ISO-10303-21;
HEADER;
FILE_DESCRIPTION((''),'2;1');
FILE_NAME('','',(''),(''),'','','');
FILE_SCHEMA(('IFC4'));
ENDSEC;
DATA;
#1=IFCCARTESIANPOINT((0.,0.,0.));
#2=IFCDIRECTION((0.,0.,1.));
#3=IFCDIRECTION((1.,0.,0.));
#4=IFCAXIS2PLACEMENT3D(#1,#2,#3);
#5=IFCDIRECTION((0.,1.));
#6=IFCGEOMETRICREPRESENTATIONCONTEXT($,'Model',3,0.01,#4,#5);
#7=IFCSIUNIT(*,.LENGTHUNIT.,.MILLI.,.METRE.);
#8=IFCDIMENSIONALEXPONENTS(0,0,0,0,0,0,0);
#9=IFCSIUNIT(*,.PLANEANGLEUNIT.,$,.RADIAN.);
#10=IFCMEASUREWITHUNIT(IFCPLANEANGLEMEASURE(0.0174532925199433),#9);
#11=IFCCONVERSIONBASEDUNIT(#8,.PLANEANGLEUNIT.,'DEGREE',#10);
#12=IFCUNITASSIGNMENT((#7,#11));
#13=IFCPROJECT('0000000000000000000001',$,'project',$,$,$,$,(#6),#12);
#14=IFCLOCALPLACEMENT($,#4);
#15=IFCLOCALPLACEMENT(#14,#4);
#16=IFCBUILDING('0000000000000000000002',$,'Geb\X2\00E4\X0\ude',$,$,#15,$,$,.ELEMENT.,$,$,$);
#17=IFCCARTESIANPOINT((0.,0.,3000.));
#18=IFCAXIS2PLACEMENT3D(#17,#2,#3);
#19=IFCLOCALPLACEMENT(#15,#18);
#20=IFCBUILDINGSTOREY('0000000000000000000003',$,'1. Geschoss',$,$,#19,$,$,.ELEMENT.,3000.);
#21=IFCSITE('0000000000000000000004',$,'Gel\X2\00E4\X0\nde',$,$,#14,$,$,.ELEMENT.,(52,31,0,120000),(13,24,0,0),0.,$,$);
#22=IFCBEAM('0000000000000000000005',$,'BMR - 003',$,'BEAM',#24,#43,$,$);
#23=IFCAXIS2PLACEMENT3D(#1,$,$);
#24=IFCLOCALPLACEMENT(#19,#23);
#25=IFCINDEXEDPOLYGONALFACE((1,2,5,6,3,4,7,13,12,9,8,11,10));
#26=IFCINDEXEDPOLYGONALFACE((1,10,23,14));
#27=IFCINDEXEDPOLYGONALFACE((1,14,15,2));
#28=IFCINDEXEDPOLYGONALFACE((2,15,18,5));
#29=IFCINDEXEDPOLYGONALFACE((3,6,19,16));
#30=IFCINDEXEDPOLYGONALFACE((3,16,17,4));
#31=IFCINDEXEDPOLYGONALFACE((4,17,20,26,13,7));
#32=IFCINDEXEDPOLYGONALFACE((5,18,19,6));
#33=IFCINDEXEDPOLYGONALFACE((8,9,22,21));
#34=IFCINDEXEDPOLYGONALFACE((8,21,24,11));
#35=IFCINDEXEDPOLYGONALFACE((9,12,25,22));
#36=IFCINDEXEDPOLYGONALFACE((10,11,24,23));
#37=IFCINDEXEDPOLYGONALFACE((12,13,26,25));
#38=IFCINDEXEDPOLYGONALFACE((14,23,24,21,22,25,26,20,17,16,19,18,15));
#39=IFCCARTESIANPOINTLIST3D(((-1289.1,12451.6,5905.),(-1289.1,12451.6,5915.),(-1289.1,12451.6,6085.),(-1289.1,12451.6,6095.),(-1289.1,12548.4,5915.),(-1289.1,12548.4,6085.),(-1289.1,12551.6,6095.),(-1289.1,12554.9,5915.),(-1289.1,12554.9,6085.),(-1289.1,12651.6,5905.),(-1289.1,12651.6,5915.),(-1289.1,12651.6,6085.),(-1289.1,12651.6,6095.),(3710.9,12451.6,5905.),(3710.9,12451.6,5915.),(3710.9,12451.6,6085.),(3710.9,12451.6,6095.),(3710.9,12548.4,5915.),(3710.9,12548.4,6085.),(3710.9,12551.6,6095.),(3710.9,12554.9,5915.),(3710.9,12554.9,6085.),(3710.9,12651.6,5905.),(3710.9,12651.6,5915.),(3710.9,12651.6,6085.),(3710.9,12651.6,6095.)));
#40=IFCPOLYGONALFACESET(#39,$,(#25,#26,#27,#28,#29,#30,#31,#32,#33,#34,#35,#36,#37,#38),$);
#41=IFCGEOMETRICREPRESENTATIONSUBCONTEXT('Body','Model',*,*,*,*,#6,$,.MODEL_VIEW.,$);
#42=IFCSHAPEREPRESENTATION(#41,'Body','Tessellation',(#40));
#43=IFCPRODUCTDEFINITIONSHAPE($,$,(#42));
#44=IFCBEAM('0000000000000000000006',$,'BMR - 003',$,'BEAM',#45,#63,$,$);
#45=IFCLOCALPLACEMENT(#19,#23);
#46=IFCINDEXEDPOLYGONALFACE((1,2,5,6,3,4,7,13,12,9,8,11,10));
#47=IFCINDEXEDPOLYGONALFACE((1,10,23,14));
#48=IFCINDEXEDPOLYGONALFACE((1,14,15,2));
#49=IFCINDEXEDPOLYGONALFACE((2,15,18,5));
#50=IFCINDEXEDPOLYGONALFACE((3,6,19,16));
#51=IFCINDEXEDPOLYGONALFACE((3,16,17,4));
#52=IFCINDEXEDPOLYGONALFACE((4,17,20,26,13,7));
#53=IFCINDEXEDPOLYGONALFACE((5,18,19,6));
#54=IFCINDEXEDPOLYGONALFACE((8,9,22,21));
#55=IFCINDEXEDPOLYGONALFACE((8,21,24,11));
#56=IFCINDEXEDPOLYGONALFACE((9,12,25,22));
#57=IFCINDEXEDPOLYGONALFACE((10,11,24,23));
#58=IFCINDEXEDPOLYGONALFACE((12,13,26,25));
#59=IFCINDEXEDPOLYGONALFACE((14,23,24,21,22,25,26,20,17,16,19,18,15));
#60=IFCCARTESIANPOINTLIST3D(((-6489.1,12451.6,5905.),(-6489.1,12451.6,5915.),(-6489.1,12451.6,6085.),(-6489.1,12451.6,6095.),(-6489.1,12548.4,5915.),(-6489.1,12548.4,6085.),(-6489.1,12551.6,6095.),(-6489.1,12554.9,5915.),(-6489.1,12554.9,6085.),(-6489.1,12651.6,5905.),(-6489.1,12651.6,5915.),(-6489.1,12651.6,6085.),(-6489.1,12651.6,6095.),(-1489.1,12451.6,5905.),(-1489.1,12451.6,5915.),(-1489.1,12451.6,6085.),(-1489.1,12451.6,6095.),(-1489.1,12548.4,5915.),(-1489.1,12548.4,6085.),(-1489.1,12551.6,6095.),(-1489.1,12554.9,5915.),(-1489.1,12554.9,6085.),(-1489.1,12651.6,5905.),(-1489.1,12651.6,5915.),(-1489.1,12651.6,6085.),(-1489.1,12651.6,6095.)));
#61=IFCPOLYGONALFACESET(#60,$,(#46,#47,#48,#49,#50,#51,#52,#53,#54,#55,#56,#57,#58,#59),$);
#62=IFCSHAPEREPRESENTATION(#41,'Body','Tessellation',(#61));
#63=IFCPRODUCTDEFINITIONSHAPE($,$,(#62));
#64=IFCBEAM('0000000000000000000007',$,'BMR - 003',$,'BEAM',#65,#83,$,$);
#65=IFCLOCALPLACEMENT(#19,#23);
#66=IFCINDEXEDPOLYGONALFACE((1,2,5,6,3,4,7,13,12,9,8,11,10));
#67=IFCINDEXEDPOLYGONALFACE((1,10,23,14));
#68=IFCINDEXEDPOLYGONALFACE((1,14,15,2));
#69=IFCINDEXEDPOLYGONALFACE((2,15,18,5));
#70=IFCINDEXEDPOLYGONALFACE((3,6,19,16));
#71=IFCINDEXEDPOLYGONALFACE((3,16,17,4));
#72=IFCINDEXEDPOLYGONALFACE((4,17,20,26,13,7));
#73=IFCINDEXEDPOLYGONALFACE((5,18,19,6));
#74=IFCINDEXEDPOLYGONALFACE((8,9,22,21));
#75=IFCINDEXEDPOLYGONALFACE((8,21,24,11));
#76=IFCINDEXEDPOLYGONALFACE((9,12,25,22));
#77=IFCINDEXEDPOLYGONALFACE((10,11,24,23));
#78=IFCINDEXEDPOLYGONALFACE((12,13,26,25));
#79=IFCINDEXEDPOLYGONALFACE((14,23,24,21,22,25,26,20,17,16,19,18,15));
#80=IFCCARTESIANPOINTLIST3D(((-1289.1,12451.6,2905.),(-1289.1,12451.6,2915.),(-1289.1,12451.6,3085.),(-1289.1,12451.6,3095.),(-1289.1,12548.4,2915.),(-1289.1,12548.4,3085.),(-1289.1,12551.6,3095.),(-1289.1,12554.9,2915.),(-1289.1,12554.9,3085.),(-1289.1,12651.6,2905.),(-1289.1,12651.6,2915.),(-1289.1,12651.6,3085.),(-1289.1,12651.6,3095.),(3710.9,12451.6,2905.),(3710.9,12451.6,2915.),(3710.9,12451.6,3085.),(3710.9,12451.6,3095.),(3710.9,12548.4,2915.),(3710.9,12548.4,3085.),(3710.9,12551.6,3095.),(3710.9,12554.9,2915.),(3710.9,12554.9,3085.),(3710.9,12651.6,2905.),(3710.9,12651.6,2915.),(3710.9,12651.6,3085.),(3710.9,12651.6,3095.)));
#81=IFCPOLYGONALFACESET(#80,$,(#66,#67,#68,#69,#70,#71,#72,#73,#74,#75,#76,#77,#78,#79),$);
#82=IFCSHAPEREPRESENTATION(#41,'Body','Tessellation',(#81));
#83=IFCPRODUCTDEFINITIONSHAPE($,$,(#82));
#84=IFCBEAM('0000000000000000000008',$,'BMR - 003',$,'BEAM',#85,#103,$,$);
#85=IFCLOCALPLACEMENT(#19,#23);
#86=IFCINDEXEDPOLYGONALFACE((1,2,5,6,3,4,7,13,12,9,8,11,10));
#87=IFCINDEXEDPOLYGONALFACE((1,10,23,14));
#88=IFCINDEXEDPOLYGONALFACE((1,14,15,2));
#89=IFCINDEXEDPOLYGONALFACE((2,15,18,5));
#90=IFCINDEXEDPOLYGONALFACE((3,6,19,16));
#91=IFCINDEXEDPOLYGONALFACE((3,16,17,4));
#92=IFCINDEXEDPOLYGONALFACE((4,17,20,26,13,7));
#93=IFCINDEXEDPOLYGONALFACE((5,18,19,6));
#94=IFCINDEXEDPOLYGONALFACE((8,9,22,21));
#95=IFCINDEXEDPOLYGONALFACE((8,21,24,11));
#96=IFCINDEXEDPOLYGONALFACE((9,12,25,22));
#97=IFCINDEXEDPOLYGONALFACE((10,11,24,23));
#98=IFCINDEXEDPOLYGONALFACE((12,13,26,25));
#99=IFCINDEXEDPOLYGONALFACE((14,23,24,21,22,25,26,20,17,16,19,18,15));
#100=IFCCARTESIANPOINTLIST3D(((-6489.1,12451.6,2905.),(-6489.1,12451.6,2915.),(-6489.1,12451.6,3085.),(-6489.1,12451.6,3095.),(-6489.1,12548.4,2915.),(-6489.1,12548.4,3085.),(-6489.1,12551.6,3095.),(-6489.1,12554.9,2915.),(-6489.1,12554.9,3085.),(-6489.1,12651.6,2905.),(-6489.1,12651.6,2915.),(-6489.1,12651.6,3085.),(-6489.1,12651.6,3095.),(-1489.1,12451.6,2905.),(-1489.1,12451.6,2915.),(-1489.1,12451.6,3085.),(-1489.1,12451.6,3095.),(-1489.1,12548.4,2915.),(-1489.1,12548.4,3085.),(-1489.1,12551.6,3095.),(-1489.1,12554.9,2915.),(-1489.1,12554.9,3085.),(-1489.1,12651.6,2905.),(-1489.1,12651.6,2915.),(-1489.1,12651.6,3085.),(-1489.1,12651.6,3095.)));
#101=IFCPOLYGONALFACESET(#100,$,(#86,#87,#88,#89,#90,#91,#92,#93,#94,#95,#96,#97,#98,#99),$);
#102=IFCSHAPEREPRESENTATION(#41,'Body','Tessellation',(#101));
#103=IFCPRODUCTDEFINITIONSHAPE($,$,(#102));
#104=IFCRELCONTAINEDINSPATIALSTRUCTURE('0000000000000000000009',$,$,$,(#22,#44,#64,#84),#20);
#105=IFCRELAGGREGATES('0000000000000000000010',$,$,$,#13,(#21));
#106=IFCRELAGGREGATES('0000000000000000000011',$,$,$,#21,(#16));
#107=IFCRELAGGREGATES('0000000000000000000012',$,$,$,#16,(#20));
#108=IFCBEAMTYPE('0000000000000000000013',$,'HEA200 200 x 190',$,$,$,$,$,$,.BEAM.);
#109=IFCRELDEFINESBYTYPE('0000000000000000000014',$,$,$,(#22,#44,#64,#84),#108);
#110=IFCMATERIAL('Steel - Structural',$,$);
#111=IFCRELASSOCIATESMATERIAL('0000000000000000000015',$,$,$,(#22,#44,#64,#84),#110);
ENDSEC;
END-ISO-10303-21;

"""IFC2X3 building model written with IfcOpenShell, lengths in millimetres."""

from ifc_helpers import new_model, entity, si_unit, converted_unit, direction, frame, origin_with_axes, place, context, subcontext, project, spatial, polyline, outline, extrude, material, type_object, element, save


model = new_model("IFC2X3")

# Units and contexts
model_context = context("Model", 3, precision=0.01, world=origin_with_axes(), true_north=direction((0.0, 1.0)))
body_context = subcontext(model_context, "Body", "Model", "MODEL_VIEW")
ifc_project = project(units=[si_unit("LENGTHUNIT", "METRE", prefix="MILLI"), converted_unit("PLANEANGLEUNIT", "DEGREE", entity("IfcPlaneAngleMeasure", 0.0174532925199433), si_unit("PLANEANGLEUNIT", "RADIAN"), dimensions=[0, 0, 0, 0, 0, 0, 0])], contexts=[model_context])

# Site, building, storey
site_placement = place(None, origin_with_axes())
site = spatial("IfcSite", under=ifc_project, at=site_placement, Name="Gelände", CompositionType="ELEMENT", RefLatitude=(52, 31, 0, 120000), RefLongitude=(13, 24, 0, 0), RefElevation=0.0)
building_placement = place(site_placement, origin_with_axes())
building = spatial("IfcBuilding", under=site, at=building_placement, Name="Gebäude", CompositionType="ELEMENT")
storey_placement = place(building_placement, frame((0.0, 0.0, 3000.0), z_axis=(0.0, 0.0, 1.0), x_axis=(1.0, 0.0, 0.0)))
storey = spatial("IfcBuildingStorey", under=building, at=storey_placement, Name="1. Geschoss", CompositionType="ELEMENT", Elevation=3000.0)

# Beams
ifc_material = material(Name="Steel - Structural")
beam_type = type_object("IfcBeamType", Name="HEA200 200 x 190", PredefinedType="BEAM")
for number, where, z_axis, x_axis, name in (
    (1, (-1289.1, 12551.6, 6000.0), (0.0, 0.0, 1.0), (0.0, -1.0, 0.0), "BMR - 003"),
    (2, (-6489.1, 12551.6, 6000.0), (0.0, 0.0, 1.0), (0.0, -1.0, 0.0), "BMR - 003"),
    (3, (-1289.1, 12551.6, 3000.0), (0.0, 0.0, 1.0), (0.0, -1.0, 0.0), "BMR - 003"),
    (4, (-6489.1, 12551.6, 3000.0), (0.0, 0.0, 1.0), (0.0, -1.0, 0.0), "BMR - 003"),
):
    element("IfcBeam", number, at=place(storey_placement, frame(where, z_axis=z_axis, x_axis=x_axis)), inside=storey, type_object=beam_type, material=ifc_material, Name=name, ObjectType="BEAM", context=body_context, shape_type="SweptSolid", body=[
        extrude(outline(polyline([(0.0, 95.0), (-100.0, 95.0), (-100.0, 85.0), (-3.2, 85.0), (-3.2, -85.0), (-100.0, -85.0), (-100.0, -95.0), (100.0, -95.0), (100.0, -85.0), (3.2, -85.0), (3.2, 85.0), (100.0, 85.0), (100.0, 95.0), (0.0, 95.0)])), frame((0.0, 5000.0, 0.0), z_axis=(0.0, -1.0, 0.0), x_axis=(1.0, 0.0, 0.0)), (0.0, 0.0, 1.0), 5000.0),
    ])

save(model, "model.ifc")
